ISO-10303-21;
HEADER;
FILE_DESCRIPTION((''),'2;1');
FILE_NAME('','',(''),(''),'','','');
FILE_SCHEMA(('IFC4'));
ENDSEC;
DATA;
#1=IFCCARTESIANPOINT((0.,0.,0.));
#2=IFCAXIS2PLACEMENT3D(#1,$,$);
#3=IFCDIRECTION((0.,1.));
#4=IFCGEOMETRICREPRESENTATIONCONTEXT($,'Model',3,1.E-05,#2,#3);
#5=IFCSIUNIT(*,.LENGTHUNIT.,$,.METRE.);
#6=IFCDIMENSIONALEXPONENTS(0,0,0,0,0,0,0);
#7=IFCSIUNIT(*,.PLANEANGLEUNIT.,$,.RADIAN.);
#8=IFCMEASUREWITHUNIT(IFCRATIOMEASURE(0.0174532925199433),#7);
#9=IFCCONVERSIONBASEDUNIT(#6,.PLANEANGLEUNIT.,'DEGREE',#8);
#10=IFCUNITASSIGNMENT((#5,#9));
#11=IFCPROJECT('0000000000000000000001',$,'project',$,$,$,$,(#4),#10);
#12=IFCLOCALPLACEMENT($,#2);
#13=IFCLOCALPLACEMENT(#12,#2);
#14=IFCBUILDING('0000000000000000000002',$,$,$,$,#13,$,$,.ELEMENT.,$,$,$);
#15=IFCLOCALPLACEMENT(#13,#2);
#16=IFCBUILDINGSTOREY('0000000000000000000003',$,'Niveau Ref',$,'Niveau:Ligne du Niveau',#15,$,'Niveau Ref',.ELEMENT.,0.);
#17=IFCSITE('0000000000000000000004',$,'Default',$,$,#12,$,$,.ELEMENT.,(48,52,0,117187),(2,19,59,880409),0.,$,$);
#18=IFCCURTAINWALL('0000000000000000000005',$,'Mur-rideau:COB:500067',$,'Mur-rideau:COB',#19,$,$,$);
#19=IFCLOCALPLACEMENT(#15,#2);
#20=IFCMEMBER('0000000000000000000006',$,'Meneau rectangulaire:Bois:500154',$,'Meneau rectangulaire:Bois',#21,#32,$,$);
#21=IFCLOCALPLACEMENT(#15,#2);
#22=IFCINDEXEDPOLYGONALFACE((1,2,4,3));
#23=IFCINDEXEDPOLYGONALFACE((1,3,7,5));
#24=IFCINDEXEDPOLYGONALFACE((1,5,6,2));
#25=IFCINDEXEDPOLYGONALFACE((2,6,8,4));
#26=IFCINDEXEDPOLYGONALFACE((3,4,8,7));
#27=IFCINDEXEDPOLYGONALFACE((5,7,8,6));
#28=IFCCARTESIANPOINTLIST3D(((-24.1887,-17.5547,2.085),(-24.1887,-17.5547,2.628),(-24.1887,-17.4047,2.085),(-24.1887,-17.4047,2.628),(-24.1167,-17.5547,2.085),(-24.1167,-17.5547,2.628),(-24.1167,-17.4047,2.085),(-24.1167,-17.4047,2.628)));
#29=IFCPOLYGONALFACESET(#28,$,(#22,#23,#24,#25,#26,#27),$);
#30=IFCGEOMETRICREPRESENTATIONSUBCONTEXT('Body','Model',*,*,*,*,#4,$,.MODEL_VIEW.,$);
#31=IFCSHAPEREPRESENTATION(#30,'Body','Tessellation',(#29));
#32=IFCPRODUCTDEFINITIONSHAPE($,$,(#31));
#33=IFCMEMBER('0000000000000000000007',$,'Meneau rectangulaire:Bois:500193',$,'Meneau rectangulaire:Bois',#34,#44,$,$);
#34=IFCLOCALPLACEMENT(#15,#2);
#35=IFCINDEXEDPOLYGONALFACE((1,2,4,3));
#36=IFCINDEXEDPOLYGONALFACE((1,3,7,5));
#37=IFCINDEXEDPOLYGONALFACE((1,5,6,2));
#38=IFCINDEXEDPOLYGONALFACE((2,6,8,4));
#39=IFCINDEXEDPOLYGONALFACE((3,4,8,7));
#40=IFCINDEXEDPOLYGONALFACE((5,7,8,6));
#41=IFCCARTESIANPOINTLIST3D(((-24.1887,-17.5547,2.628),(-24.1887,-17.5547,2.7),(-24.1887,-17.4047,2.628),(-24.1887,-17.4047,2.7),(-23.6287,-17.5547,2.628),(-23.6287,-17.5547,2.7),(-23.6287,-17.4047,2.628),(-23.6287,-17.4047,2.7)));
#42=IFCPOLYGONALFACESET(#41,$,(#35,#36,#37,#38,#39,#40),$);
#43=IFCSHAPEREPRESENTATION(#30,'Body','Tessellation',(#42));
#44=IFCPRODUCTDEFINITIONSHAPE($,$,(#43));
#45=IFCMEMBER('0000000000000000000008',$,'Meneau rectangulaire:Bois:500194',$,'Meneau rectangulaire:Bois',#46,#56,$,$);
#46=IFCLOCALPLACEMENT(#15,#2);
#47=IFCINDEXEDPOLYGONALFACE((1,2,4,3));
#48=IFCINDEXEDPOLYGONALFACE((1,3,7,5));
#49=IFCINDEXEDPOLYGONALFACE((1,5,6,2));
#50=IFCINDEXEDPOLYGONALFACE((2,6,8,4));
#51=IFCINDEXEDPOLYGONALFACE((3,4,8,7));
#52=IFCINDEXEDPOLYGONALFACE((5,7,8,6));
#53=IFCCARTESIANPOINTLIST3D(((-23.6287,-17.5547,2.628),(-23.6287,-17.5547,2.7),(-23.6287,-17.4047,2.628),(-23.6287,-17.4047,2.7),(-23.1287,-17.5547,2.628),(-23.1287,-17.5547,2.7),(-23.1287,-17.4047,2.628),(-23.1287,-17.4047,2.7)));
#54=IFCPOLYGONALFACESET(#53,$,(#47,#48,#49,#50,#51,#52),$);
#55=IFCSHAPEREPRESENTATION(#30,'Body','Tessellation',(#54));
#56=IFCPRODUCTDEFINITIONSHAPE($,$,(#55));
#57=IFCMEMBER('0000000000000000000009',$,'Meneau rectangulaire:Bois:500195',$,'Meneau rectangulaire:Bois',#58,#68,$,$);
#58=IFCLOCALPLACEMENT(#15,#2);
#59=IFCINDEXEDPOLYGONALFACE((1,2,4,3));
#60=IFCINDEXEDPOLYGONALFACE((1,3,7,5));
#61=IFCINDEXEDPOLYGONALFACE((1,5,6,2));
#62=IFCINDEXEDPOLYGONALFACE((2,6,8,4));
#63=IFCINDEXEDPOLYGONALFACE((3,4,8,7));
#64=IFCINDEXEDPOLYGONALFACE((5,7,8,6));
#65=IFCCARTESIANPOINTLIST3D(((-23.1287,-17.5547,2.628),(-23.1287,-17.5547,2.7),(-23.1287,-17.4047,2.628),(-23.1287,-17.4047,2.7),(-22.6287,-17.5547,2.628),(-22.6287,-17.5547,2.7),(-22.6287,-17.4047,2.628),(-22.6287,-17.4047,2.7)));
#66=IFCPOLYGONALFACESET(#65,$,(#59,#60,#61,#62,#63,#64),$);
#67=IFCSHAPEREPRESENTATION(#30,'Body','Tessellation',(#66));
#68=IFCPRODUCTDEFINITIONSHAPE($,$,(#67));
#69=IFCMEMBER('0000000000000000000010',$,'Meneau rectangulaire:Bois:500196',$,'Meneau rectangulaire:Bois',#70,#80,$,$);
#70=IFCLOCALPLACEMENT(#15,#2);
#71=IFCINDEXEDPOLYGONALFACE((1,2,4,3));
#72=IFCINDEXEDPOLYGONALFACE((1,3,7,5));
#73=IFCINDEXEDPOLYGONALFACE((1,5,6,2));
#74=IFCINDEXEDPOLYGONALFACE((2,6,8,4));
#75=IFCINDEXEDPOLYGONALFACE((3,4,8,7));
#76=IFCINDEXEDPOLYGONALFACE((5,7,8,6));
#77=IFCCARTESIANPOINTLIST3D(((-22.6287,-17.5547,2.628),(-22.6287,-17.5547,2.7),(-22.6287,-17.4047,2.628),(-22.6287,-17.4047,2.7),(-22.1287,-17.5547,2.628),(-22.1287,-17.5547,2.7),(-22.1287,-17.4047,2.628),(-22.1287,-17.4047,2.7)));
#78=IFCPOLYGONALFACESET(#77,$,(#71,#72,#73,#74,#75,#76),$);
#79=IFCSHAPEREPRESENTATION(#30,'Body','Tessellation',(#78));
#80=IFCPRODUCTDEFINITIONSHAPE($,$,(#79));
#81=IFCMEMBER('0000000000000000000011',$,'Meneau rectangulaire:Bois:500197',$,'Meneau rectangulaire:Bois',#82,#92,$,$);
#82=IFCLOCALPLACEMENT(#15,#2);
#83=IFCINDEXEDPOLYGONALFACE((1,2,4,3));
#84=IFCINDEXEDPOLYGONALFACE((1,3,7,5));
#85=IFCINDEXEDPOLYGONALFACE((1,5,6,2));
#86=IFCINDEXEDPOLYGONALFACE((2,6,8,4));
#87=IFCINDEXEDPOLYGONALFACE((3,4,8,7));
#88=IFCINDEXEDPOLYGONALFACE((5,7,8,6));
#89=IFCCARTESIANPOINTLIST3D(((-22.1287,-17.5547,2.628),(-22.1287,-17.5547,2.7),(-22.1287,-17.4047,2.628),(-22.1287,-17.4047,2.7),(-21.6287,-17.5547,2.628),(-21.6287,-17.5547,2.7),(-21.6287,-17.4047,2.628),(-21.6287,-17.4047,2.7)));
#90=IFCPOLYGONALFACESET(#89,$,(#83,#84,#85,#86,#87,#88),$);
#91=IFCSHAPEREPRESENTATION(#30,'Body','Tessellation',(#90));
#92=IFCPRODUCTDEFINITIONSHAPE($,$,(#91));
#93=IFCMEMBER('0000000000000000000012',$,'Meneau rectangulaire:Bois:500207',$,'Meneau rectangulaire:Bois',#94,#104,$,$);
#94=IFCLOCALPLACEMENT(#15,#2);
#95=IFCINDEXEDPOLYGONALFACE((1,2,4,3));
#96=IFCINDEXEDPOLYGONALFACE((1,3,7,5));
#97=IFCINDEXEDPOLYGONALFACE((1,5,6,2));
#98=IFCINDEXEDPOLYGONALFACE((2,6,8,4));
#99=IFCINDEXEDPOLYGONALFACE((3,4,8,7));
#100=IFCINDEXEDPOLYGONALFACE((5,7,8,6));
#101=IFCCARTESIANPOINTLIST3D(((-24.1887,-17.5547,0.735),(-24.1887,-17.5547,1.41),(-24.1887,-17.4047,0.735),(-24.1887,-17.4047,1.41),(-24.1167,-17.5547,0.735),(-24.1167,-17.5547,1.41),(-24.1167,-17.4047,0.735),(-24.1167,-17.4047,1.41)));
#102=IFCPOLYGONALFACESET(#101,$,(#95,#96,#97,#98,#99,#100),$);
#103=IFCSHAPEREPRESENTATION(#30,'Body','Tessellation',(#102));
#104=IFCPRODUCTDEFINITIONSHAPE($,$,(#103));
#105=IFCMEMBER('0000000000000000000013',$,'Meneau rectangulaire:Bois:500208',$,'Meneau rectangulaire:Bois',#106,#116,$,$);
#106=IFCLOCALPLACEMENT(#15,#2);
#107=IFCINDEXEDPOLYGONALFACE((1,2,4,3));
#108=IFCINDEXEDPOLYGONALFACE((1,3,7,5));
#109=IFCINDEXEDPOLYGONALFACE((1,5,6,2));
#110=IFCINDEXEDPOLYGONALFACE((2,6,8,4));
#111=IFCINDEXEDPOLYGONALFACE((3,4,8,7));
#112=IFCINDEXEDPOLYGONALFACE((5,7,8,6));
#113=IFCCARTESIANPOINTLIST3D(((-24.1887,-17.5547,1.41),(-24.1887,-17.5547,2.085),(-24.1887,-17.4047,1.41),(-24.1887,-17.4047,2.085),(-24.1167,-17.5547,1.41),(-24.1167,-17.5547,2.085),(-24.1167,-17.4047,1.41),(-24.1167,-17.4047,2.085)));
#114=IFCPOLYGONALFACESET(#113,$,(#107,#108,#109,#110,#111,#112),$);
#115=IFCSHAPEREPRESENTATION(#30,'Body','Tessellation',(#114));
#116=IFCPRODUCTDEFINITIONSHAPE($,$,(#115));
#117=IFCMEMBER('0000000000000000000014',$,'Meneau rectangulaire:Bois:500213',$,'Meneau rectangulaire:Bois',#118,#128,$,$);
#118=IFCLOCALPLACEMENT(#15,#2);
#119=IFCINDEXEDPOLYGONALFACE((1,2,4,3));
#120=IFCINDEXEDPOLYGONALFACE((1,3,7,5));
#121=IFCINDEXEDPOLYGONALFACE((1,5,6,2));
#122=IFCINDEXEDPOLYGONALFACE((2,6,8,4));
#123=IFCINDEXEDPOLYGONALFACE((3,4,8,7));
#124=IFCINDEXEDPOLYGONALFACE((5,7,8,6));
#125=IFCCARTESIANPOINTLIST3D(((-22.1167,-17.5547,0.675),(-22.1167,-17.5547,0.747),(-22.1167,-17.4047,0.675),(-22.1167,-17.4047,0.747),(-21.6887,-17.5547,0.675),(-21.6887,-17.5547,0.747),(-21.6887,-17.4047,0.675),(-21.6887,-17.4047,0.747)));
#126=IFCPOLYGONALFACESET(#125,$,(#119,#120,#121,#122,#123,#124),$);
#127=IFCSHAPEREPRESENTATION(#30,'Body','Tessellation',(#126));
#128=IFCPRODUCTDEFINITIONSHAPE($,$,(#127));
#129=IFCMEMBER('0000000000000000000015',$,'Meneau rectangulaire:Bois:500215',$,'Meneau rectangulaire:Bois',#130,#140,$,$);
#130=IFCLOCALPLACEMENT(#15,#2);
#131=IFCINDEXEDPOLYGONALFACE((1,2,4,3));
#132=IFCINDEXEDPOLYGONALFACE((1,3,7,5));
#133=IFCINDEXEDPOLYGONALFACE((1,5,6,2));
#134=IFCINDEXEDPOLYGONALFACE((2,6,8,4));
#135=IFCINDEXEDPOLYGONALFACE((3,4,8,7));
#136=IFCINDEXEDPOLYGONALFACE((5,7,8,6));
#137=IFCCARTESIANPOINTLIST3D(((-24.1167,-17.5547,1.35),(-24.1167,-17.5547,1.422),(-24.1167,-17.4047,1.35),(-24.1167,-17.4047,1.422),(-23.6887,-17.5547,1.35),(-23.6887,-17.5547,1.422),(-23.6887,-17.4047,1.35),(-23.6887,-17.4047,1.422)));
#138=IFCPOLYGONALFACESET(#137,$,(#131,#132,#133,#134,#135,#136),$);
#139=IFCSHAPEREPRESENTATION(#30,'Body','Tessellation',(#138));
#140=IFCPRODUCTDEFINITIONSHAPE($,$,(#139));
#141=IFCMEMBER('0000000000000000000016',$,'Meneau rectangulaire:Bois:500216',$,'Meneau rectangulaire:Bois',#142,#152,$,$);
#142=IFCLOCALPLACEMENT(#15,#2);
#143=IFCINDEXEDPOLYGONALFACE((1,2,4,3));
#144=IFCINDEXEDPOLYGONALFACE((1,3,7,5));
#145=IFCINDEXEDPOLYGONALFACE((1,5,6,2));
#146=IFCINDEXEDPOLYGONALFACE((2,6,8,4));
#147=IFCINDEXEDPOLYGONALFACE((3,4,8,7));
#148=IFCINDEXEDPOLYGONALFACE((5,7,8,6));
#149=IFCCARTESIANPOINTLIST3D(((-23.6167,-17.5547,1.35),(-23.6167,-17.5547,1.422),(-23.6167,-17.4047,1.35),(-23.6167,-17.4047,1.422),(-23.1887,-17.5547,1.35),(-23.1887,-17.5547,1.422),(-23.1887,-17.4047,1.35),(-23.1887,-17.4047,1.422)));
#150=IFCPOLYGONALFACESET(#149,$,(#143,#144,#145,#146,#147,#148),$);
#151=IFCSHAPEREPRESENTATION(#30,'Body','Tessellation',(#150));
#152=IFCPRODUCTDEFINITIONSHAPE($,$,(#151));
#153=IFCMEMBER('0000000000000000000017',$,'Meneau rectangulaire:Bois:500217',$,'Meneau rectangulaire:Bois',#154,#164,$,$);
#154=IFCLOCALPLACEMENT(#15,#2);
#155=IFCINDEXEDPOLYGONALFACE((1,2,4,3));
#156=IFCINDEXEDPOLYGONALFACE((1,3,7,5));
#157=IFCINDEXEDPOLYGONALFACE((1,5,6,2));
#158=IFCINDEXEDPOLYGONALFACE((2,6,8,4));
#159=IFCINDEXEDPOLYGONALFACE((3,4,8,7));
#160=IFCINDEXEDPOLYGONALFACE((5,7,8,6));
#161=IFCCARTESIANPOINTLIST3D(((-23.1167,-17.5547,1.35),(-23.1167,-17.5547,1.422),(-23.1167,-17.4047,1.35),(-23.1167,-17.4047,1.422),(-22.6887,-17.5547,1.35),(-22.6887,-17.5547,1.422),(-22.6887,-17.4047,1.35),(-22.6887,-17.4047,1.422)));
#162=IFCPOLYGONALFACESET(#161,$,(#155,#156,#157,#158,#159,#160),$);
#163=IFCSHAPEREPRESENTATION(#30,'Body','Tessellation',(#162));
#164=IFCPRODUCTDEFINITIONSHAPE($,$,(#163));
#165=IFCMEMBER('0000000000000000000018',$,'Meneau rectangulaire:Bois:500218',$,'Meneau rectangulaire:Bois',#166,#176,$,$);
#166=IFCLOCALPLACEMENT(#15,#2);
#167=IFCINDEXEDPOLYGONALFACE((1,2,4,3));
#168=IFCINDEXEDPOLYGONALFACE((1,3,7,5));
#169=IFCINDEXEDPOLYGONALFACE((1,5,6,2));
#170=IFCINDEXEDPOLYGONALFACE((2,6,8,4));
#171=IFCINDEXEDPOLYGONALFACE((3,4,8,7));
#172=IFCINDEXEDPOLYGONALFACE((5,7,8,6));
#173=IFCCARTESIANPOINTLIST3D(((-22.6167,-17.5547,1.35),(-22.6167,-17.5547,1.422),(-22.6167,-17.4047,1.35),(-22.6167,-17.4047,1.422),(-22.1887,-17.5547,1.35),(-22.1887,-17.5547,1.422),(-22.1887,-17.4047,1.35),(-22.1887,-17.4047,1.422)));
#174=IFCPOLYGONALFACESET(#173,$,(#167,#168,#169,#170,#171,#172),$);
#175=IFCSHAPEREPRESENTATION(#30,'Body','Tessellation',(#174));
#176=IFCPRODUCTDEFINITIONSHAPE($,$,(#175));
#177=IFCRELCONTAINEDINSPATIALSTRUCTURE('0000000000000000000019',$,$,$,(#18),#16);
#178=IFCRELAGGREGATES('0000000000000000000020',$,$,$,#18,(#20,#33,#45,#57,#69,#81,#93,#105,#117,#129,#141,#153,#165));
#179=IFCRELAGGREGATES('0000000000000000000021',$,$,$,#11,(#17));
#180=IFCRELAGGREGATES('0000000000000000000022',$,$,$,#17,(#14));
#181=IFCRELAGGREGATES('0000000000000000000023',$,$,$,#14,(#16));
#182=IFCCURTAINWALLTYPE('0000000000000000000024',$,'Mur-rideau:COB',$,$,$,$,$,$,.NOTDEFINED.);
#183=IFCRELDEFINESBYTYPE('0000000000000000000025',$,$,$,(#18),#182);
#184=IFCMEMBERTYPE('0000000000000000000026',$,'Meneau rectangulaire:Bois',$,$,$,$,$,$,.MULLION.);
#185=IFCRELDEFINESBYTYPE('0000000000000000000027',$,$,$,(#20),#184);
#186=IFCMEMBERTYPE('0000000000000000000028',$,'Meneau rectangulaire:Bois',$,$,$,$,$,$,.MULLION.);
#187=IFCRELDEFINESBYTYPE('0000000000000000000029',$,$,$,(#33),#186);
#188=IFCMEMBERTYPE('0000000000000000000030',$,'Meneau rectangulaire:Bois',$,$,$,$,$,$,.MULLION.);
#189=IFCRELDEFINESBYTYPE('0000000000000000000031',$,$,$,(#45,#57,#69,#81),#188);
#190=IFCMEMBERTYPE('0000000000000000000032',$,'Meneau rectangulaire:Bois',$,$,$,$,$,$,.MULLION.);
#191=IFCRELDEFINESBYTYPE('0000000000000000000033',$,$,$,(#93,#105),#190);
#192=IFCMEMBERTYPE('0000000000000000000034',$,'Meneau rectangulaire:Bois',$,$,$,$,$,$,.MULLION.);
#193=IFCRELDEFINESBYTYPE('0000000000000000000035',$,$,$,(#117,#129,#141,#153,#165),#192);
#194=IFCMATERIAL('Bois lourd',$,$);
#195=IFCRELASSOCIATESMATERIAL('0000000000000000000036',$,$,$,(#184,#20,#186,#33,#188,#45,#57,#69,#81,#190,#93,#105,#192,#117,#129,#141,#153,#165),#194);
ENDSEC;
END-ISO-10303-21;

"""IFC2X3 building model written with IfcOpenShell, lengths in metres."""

from ifc_helpers import new_model, entity, si_unit, converted_unit, direction, frame, origin, origin_2d_with_axis, place, context, subcontext, project, spatial, rectangle, extrude, source, transform, mapped, material, type_object, type_shapes, element, aggregate, save


model = new_model("IFC2X3")

# Units and contexts
model_context = context("Model", 3, precision=1e-05, world=origin(), true_north=direction((0.0, 1.0)))
body_context = subcontext(model_context, "Body", "Model", "MODEL_VIEW")
ifc_project = project(units=[si_unit("LENGTHUNIT", "METRE"), converted_unit("PLANEANGLEUNIT", "DEGREE", entity("IfcRatioMeasure", 0.0174532925199433), si_unit("PLANEANGLEUNIT", "RADIAN"), dimensions=[0, 0, 0, 0, 0, 0, 0])], contexts=[model_context])

# Site, building, storey
site_placement = place(None, origin())
site = spatial("IfcSite", under=ifc_project, at=site_placement, Name="Default", CompositionType="ELEMENT", RefLatitude=(48, 52, 0, 117187), RefLongitude=(2, 19, 59, 880409), RefElevation=0.0)
building_placement = place(site_placement, origin())
building = spatial("IfcBuilding", under=site, at=building_placement, CompositionType="ELEMENT")
storey_placement = place(building_placement, origin())
storey = spatial("IfcBuildingStorey", under=building, at=storey_placement, Name="Niveau Ref", ObjectType="Niveau:Ligne du Niveau", LongName="Niveau Ref", CompositionType="ELEMENT", Elevation=0.0)

# Curtain wall, members
curtain_wall_type = type_object("IfcCurtainWallType", Name="Mur-rideau:COB", PredefinedType="NOTDEFINED")
curtain_wall_placement = place(storey_placement, origin())
curtain_wall = element("IfcCurtainWall", 1, at=curtain_wall_placement, inside=storey, type_object=curtain_wall_type, Name="Mur-rideau:COB:500067", ObjectType="Mur-rideau:COB")
ifc_material = material(Name="Bois lourd")
member_type_1 = type_object("IfcMemberType", Name="Meneau rectangulaire:Bois", PredefinedType="MULLION", material=ifc_material)
shared_shape_1 = source(origin(), body_context, "Body", "SweptSolid", [
    extrude(rectangle(XDim=0.15, YDim=0.072, at=origin_2d_with_axis()), frame((-0.036, 0.0, -0.543), z_axis=(0.0, 0.0, 1.0), x_axis=(0.0, -1.0, 0.0)), (0.0, 0.0, 1.0), 0.543),
])
type_shapes(member_type_1, [shared_shape_1])
member_1_placement = place(storey_placement, frame((-24.1887, -17.4797, 2.628), z_axis=(0.0, 0.0, 1.0), x_axis=(-1.0, 0.0, 0.0)))
member_1 = element("IfcMember", 2, at=member_1_placement, type_object=member_type_1, material=ifc_material, Name="Meneau rectangulaire:Bois:500154", ObjectType="Meneau rectangulaire:Bois", context=body_context, shape_type="MappedRepresentation", body=[
    mapped(shared_shape_1, transform((0.0, 0.0, 0.0), scale=1.0)),
])
member_type_2 = type_object("IfcMemberType", Name="Meneau rectangulaire:Bois", PredefinedType="MULLION", material=ifc_material)
shared_shape_2 = source(origin(), body_context, "Body", "SweptSolid", [
    extrude(rectangle(XDim=0.15, YDim=0.072, at=origin_2d_with_axis()), frame((-0.036, 0.0, -0.56), z_axis=(0.0, 0.0, 1.0), x_axis=(0.0, -1.0, 0.0)), (0.0, 0.0, 1.0), 0.56),
])
type_shapes(member_type_2, [shared_shape_2])
member_2_placement = place(storey_placement, frame((-23.6287, -17.4797, 2.7), z_axis=(1.0, 0.0, 0.0), x_axis=(0.0, 0.0, 1.0)))
member_2 = element("IfcMember", 3, at=member_2_placement, type_object=member_type_2, material=ifc_material, Name="Meneau rectangulaire:Bois:500193", ObjectType="Meneau rectangulaire:Bois", context=body_context, shape_type="MappedRepresentation", body=[
    mapped(shared_shape_2, transform((0.0, 0.0, 0.0), scale=1.0)),
])
member_type_3 = type_object("IfcMemberType", Name="Meneau rectangulaire:Bois", PredefinedType="MULLION", material=ifc_material)
shared_shape_3 = source(origin(), body_context, "Body", "SweptSolid", [
    extrude(rectangle(XDim=0.15, YDim=0.072, at=origin_2d_with_axis()), frame((-0.036, 0.0, -0.5), z_axis=(0.0, 0.0, 1.0), x_axis=(0.0, -1.0, 0.0)), (0.0, 0.0, 1.0), 0.5),
])
type_shapes(member_type_3, [shared_shape_3])
member_3_placement = place(storey_placement, frame((-23.1287, -17.4797, 2.7), z_axis=(1.0, 0.0, 0.0), x_axis=(0.0, 0.0, 1.0)))
member_3 = element("IfcMember", 4, at=member_3_placement, type_object=member_type_3, material=ifc_material, Name="Meneau rectangulaire:Bois:500194", ObjectType="Meneau rectangulaire:Bois", context=body_context, shape_type="MappedRepresentation", body=[
    mapped(shared_shape_3, transform((0.0, 0.0, 0.0), scale=1.0)),
])
member_4_placement = place(storey_placement, frame((-22.6287, -17.4797, 2.7), z_axis=(1.0, 0.0, 0.0), x_axis=(0.0, 0.0, 1.0)))
member_4 = element("IfcMember", 5, at=member_4_placement, type_object=member_type_3, material=ifc_material, Name="Meneau rectangulaire:Bois:500195", ObjectType="Meneau rectangulaire:Bois", context=body_context, shape_type="MappedRepresentation", body=[
    mapped(shared_shape_3, transform((0.0, 0.0, 0.0), scale=1.0)),
])
member_5_placement = place(storey_placement, frame((-22.1287, -17.4797, 2.7), z_axis=(1.0, 0.0, 0.0), x_axis=(0.0, 0.0, 1.0)))
member_5 = element("IfcMember", 6, at=member_5_placement, type_object=member_type_3, material=ifc_material, Name="Meneau rectangulaire:Bois:500196", ObjectType="Meneau rectangulaire:Bois", context=body_context, shape_type="MappedRepresentation", body=[
    mapped(shared_shape_3, transform((0.0, 0.0, 0.0), scale=1.0)),
])
member_6_placement = place(storey_placement, frame((-21.6287, -17.4797, 2.7), z_axis=(1.0, 0.0, 0.0), x_axis=(0.0, 0.0, 1.0)))
member_6 = element("IfcMember", 7, at=member_6_placement, type_object=member_type_3, material=ifc_material, Name="Meneau rectangulaire:Bois:500197", ObjectType="Meneau rectangulaire:Bois", context=body_context, shape_type="MappedRepresentation", body=[
    mapped(shared_shape_3, transform((0.0, 0.0, 0.0), scale=1.0)),
])
member_type_4 = type_object("IfcMemberType", Name="Meneau rectangulaire:Bois", PredefinedType="MULLION", material=ifc_material)
shared_shape_4 = source(origin(), body_context, "Body", "SweptSolid", [
    extrude(rectangle(XDim=0.15, YDim=0.072, at=origin_2d_with_axis()), frame((-0.036, 0.0, -0.675), z_axis=(0.0, 0.0, 1.0), x_axis=(0.0, -1.0, 0.0)), (0.0, 0.0, 1.0), 0.675),
])
type_shapes(member_type_4, [shared_shape_4])
member_7_placement = place(storey_placement, frame((-24.1887, -17.4797, 1.41), z_axis=(0.0, 0.0, 1.0), x_axis=(-1.0, 0.0, 0.0)))
member_7 = element("IfcMember", 8, at=member_7_placement, type_object=member_type_4, material=ifc_material, Name="Meneau rectangulaire:Bois:500207", ObjectType="Meneau rectangulaire:Bois", context=body_context, shape_type="MappedRepresentation", body=[
    mapped(shared_shape_4, transform((0.0, 0.0, 0.0), scale=1.0)),
])
member_8_placement = place(storey_placement, frame((-24.1887, -17.4797, 2.085), z_axis=(0.0, 0.0, 1.0), x_axis=(-1.0, 0.0, 0.0)))
member_8 = element("IfcMember", 9, at=member_8_placement, type_object=member_type_4, material=ifc_material, Name="Meneau rectangulaire:Bois:500208", ObjectType="Meneau rectangulaire:Bois", context=body_context, shape_type="MappedRepresentation", body=[
    mapped(shared_shape_4, transform((0.0, 0.0, 0.0), scale=1.0)),
])
member_type_5 = type_object("IfcMemberType", Name="Meneau rectangulaire:Bois", PredefinedType="MULLION", material=ifc_material)
shared_shape_5 = source(origin(), body_context, "Body", "SweptSolid", [
    extrude(rectangle(XDim=0.15, YDim=0.072, at=origin_2d_with_axis()), frame((-0.024, 0.0, -0.428), z_axis=(0.0, 0.0, 1.0), x_axis=(0.0, -1.0, 0.0)), (0.0, 0.0, 1.0), 0.428),
])
type_shapes(member_type_5, [shared_shape_5])
member_9_placement = place(storey_placement, frame((-21.6887, -17.4797, 0.735), z_axis=(1.0, 0.0, 0.0), x_axis=(0.0, 0.0, 1.0)))
member_9 = element("IfcMember", 10, at=member_9_placement, type_object=member_type_5, material=ifc_material, Name="Meneau rectangulaire:Bois:500213", ObjectType="Meneau rectangulaire:Bois", context=body_context, shape_type="MappedRepresentation", body=[
    mapped(shared_shape_5, transform((0.0, 0.0, 0.0), scale=1.0)),
])
member_10_placement = place(storey_placement, frame((-23.6887, -17.4797, 1.41), z_axis=(1.0, 0.0, 0.0), x_axis=(0.0, 0.0, 1.0)))
member_10 = element("IfcMember", 11, at=member_10_placement, type_object=member_type_5, material=ifc_material, Name="Meneau rectangulaire:Bois:500215", ObjectType="Meneau rectangulaire:Bois", context=body_context, shape_type="MappedRepresentation", body=[
    mapped(shared_shape_5, transform((0.0, 0.0, 0.0), scale=1.0)),
])
member_11_placement = place(storey_placement, frame((-23.1887, -17.4797, 1.41), z_axis=(1.0, 0.0, 0.0), x_axis=(0.0, 0.0, 1.0)))
member_11 = element("IfcMember", 12, at=member_11_placement, type_object=member_type_5, material=ifc_material, Name="Meneau rectangulaire:Bois:500216", ObjectType="Meneau rectangulaire:Bois", context=body_context, shape_type="MappedRepresentation", body=[
    mapped(shared_shape_5, transform((0.0, 0.0, 0.0), scale=1.0)),
])
member_12_placement = place(storey_placement, frame((-22.6887, -17.4797, 1.41), z_axis=(1.0, 0.0, 0.0), x_axis=(0.0, 0.0, 1.0)))
member_12 = element("IfcMember", 13, at=member_12_placement, type_object=member_type_5, material=ifc_material, Name="Meneau rectangulaire:Bois:500217", ObjectType="Meneau rectangulaire:Bois", context=body_context, shape_type="MappedRepresentation", body=[
    mapped(shared_shape_5, transform((0.0, 0.0, 0.0), scale=1.0)),
])
member_13_placement = place(storey_placement, frame((-22.1887, -17.4797, 1.41), z_axis=(1.0, 0.0, 0.0), x_axis=(0.0, 0.0, 1.0)))
member_13 = element("IfcMember", 14, at=member_13_placement, type_object=member_type_5, material=ifc_material, Name="Meneau rectangulaire:Bois:500218", ObjectType="Meneau rectangulaire:Bois", context=body_context, shape_type="MappedRepresentation", body=[
    mapped(shared_shape_5, transform((0.0, 0.0, 0.0), scale=1.0)),
])
aggregate(curtain_wall, [member_1, member_2, member_3, member_4, member_5, member_6, member_7, member_8, member_9, member_10, member_11, member_12, member_13])

save(model, "model.ifc")
